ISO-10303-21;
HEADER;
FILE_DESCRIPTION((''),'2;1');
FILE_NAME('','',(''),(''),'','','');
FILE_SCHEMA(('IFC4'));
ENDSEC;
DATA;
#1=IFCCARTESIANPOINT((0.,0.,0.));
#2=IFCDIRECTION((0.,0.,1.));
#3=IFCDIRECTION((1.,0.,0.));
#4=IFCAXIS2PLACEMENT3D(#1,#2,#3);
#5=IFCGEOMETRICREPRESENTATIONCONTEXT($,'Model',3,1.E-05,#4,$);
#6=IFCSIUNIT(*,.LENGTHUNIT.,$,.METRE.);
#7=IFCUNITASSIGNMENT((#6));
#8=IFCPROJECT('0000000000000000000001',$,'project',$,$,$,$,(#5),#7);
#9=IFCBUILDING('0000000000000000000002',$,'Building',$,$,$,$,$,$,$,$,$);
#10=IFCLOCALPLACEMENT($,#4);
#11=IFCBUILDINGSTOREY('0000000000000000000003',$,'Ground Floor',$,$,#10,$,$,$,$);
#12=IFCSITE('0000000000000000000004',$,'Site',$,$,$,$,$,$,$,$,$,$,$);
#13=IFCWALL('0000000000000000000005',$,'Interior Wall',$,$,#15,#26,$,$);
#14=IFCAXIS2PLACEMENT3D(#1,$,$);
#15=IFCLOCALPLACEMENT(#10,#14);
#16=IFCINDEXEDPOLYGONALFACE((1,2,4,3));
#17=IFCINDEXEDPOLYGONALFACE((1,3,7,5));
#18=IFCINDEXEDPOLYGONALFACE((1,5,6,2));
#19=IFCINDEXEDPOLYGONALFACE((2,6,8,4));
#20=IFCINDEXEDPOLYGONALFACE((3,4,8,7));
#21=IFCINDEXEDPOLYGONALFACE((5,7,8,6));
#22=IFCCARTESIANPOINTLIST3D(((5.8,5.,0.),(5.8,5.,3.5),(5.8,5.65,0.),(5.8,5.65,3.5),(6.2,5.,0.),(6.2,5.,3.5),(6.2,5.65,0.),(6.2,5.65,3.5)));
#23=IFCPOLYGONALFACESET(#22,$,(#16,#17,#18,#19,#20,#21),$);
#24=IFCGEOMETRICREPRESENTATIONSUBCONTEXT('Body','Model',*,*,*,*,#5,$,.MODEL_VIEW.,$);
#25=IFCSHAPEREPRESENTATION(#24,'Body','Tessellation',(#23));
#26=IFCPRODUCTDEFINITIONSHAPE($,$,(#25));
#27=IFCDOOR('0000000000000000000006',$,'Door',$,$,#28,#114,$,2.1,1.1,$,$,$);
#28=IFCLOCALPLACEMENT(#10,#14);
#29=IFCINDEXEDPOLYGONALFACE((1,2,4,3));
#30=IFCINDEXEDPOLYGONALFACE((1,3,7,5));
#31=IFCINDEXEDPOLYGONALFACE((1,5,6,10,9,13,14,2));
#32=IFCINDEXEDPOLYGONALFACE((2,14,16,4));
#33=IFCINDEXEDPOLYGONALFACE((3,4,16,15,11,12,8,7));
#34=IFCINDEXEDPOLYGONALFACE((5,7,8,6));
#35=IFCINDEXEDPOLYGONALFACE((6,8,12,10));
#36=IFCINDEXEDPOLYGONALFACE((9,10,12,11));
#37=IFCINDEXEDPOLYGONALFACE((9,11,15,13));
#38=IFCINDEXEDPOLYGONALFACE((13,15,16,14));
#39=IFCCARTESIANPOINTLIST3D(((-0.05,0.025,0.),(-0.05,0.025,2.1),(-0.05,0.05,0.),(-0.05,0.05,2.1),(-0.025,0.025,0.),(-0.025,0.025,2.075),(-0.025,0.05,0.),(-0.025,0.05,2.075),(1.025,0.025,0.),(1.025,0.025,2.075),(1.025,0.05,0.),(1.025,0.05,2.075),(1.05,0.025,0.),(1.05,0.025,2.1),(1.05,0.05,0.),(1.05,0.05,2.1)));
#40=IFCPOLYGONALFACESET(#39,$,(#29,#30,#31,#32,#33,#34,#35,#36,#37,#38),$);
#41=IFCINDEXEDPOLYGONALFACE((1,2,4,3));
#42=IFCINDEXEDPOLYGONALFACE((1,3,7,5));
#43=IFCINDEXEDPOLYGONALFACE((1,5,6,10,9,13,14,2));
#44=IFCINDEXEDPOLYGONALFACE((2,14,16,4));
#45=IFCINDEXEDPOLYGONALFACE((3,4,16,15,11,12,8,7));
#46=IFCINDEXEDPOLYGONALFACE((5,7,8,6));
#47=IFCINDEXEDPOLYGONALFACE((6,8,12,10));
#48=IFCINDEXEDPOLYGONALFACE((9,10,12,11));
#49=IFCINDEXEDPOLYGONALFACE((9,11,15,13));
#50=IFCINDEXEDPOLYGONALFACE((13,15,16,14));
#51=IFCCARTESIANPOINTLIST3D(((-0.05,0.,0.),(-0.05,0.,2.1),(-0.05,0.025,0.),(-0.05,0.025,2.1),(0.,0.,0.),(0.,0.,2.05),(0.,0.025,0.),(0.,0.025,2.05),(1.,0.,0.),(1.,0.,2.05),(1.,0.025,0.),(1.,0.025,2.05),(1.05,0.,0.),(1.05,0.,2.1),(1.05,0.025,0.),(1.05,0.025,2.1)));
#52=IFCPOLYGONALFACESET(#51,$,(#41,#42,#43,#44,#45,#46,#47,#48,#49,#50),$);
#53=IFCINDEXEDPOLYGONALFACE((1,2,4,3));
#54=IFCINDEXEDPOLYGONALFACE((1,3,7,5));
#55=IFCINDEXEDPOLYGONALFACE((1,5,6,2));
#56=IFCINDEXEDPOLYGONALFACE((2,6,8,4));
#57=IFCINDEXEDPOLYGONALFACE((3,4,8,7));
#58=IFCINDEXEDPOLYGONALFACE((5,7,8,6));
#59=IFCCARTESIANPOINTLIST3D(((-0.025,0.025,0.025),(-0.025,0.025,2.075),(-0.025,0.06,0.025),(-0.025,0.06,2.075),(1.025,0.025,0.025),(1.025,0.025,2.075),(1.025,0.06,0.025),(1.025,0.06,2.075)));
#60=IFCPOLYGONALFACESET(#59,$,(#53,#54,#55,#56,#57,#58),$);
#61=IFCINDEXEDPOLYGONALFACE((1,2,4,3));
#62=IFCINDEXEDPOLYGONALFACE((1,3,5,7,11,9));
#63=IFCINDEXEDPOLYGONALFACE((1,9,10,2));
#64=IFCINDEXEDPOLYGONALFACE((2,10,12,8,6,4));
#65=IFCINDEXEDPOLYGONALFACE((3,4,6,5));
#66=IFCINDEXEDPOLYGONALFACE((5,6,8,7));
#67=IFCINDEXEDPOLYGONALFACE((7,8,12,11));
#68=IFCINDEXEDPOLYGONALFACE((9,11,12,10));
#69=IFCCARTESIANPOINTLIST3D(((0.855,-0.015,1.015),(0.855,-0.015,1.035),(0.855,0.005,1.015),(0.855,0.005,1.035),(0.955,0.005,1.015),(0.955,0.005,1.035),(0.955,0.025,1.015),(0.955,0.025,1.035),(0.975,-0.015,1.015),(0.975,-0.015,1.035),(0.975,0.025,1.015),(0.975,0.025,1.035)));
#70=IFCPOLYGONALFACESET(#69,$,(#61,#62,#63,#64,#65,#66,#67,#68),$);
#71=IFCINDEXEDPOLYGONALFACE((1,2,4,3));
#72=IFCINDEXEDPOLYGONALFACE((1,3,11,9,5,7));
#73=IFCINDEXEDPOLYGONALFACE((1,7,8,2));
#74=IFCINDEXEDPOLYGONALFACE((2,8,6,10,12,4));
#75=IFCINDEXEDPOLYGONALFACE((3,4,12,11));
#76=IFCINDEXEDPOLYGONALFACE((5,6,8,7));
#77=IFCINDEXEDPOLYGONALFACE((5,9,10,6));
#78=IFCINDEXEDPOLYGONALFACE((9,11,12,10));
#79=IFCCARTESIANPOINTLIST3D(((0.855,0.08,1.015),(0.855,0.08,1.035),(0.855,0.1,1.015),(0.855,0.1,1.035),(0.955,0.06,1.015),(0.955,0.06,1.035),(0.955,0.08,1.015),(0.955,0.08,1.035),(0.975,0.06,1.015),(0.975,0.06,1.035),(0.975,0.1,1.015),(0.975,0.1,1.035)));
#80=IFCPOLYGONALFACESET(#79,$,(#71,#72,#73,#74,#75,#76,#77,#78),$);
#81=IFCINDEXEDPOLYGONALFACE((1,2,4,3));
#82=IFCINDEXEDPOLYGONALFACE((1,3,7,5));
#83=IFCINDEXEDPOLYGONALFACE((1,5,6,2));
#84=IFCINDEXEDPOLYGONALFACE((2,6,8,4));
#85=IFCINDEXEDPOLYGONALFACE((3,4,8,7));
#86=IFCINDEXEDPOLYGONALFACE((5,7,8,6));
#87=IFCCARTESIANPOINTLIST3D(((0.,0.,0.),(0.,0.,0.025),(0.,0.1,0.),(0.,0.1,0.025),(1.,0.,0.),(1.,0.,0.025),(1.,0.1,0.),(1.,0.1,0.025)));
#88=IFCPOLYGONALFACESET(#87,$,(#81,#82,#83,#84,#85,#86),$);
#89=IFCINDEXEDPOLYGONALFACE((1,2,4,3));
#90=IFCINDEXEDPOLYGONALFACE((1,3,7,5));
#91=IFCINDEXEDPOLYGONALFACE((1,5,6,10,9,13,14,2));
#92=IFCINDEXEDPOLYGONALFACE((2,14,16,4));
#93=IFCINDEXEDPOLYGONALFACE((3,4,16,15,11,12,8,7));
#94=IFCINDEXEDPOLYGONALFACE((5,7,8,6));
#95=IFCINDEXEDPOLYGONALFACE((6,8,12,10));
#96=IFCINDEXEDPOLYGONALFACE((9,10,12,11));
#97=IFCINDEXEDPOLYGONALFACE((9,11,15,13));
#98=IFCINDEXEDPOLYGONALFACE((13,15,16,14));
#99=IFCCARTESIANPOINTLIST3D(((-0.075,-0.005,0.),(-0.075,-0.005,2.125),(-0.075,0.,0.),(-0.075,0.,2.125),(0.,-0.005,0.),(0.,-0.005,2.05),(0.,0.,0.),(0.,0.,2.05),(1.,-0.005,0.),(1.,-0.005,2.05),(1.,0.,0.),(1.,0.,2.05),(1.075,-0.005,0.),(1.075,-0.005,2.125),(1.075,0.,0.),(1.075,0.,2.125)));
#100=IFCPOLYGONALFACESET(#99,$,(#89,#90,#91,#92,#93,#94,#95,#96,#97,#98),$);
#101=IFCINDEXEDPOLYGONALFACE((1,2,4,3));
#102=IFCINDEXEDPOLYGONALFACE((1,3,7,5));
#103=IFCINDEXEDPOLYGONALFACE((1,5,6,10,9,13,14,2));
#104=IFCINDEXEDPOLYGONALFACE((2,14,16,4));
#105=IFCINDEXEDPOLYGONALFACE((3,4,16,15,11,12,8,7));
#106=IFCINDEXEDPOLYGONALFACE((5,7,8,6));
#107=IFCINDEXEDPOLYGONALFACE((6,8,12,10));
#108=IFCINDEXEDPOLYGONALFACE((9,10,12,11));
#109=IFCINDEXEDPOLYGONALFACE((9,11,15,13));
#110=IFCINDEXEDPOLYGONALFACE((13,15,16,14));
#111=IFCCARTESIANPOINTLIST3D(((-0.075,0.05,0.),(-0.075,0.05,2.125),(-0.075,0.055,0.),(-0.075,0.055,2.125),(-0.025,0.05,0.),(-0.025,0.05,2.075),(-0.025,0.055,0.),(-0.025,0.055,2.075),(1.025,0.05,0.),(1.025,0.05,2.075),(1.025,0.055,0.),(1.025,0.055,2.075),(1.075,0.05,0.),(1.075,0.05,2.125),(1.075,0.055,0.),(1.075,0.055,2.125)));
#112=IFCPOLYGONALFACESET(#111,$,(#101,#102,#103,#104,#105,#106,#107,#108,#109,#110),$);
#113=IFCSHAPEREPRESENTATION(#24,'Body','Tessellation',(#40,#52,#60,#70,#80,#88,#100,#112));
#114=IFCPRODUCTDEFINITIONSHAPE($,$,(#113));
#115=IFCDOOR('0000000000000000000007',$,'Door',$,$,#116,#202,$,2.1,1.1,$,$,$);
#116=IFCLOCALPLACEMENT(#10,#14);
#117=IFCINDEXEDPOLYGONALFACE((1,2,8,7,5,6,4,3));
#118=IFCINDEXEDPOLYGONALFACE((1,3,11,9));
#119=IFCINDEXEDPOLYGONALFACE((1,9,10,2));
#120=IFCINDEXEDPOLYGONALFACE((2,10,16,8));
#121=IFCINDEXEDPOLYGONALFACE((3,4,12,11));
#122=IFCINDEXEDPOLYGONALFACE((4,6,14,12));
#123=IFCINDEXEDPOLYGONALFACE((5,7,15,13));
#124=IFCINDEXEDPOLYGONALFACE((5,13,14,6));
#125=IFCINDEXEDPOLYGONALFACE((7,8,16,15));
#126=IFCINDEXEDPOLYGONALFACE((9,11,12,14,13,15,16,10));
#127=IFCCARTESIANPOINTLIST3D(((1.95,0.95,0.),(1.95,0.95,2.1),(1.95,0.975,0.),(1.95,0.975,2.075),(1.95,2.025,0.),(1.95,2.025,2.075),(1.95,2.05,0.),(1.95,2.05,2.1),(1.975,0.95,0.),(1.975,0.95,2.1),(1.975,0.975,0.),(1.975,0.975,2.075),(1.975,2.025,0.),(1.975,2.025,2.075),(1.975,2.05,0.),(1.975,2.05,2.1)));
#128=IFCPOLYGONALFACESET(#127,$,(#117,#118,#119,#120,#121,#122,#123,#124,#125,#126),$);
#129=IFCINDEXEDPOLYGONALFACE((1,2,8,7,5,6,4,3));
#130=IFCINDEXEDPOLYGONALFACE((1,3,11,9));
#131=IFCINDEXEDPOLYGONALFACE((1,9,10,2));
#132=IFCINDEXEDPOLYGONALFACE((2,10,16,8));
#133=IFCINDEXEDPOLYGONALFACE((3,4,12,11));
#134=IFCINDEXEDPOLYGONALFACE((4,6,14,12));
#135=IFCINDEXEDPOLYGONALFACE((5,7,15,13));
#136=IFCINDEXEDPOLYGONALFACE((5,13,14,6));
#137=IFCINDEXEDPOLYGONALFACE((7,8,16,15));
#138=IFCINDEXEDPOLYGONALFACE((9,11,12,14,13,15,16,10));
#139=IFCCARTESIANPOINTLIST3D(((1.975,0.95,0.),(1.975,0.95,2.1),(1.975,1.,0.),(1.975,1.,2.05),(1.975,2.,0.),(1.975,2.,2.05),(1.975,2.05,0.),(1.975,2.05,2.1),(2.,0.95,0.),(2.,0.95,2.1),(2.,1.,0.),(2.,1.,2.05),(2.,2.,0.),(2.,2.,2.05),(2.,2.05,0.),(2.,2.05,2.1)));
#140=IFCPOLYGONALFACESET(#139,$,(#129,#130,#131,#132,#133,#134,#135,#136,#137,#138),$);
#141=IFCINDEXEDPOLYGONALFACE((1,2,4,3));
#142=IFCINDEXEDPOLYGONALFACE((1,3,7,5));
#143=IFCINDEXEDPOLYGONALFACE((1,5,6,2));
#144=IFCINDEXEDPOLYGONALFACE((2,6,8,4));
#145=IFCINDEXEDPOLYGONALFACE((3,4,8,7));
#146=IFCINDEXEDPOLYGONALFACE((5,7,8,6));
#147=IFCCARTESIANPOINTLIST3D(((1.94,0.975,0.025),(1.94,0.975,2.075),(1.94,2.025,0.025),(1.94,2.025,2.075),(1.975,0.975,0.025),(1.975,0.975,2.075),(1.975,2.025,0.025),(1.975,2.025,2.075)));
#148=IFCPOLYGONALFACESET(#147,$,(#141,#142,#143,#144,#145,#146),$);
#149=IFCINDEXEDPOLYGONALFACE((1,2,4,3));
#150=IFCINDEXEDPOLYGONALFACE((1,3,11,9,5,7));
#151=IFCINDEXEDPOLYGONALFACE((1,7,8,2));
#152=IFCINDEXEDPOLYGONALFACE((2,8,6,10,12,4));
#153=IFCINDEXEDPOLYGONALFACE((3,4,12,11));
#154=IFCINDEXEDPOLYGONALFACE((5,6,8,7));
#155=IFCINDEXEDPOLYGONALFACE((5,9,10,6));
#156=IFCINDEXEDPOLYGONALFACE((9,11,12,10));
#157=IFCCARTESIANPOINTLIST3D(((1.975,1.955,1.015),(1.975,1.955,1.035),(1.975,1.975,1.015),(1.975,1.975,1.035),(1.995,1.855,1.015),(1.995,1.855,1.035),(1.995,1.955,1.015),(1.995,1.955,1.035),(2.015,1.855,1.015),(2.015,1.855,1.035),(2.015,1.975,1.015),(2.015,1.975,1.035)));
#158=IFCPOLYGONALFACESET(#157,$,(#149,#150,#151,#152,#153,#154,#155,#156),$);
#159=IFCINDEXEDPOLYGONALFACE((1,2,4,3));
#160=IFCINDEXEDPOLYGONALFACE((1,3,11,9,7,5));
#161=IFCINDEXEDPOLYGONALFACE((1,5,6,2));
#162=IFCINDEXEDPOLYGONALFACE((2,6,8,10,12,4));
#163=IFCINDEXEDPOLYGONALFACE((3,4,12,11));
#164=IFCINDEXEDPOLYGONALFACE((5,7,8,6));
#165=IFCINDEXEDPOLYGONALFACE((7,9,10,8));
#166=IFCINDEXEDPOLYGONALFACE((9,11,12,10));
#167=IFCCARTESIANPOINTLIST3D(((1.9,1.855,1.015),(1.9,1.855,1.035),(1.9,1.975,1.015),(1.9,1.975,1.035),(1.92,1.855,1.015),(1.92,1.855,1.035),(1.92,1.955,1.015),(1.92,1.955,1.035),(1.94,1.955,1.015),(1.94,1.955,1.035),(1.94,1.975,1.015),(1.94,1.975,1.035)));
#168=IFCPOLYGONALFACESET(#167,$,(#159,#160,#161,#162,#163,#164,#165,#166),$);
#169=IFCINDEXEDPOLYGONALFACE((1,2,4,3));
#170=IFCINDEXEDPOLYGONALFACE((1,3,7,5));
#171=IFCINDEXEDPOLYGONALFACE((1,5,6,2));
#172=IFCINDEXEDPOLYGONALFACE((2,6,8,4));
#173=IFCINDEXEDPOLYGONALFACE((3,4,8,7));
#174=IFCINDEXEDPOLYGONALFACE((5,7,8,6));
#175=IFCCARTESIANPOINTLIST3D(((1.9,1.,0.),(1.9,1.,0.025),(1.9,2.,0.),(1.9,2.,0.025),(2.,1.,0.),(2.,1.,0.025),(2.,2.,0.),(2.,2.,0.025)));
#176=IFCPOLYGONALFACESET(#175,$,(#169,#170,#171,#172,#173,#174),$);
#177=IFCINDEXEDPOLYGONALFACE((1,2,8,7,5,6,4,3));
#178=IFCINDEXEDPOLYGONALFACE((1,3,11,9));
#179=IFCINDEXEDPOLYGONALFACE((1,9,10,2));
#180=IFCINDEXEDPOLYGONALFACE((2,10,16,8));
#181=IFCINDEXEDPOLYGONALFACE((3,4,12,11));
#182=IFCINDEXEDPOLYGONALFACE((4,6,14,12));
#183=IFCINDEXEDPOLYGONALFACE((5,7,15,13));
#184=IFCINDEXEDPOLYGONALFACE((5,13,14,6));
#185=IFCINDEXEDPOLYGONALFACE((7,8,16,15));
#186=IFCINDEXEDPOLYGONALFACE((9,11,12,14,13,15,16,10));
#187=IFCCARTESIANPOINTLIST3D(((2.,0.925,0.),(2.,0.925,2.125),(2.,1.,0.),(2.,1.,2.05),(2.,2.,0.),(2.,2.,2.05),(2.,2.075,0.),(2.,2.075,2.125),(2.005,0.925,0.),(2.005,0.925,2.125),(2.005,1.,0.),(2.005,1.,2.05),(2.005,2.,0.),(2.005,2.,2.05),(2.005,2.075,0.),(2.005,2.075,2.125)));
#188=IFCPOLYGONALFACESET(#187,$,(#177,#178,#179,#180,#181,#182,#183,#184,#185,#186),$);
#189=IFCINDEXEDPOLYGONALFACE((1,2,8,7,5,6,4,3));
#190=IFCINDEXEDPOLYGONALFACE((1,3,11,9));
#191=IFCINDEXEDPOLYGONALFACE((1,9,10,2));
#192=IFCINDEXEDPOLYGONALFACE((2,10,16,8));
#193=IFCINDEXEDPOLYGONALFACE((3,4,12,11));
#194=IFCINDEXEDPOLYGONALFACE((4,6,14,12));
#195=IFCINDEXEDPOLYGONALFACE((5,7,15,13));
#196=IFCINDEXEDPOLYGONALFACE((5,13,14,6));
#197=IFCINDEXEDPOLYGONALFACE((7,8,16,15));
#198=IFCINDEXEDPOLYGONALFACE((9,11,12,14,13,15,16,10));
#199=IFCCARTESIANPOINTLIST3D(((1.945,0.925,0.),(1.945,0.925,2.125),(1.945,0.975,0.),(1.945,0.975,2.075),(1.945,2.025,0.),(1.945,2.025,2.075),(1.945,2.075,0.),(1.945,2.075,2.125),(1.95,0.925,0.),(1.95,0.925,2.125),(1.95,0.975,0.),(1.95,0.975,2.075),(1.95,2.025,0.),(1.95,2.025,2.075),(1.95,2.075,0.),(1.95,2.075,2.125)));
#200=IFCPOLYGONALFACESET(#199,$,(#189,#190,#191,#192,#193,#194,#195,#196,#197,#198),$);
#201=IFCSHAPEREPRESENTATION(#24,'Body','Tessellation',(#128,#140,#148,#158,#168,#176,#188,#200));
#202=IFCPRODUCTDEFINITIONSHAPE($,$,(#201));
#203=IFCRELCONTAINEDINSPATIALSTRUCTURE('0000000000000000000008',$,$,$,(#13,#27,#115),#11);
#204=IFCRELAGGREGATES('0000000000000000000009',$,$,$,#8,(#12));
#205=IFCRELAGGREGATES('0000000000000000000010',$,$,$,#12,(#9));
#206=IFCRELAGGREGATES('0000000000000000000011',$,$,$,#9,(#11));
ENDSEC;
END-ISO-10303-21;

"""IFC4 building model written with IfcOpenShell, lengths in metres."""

from ifc_helpers import new_model, si_unit, frame, origin_with_axes, place, context, subcontext, project, spatial, line, indexed_curve, outline, extrude, element, save


model = new_model("IFC4")

# Units and contexts
model_context = context("Model", 3, precision=1e-05, world=origin_with_axes())
body_context = subcontext(model_context, "Body", "Model", "MODEL_VIEW")
ifc_project = project(units=[si_unit("LENGTHUNIT", "METRE")], contexts=[model_context])

# Site, building, storey
site = spatial("IfcSite", under=ifc_project, Name="Site")
building = spatial("IfcBuilding", under=site, Name="Building")
storey_placement = place(None, origin_with_axes())
storey = spatial("IfcBuildingStorey", under=building, at=storey_placement, Name="Ground Floor")

# Wall
wall_1_placement = place(storey_placement, frame((6.0, 5.0, 0.0), z_axis=(0.0, 0.0, 1.0), x_axis=(0.0, 1.0, 0.0)))
element("IfcWall", 1, at=wall_1_placement, inside=storey, Name="Interior Wall", context=body_context, shape_type="SweptSolid", body=[
    extrude(outline(indexed_curve([(0.0, 0.0), (0.0, 0.4), (0.65, 0.4), (0.65, 0.0), (0.0, 0.0)], self_intersect=False)), frame((0.0, -0.2, 0.0), z_axis=(0.0, 0.0, 1.0), x_axis=(1.0, 0.0, 0.0)), (0.0, 0.0, 1.0), 3.5),
])

# Doors
door_1_placement = place(storey_placement, frame((-0.05, 0.0, 0.0), z_axis=(0.0, 0.0, 1.0), x_axis=(1.0, 0.0, 0.0)))
element("IfcDoor", 2, at=door_1_placement, inside=storey, Name="Door", OverallHeight=2.1, OverallWidth=1.1, context=body_context, shape_type="SweptSolid", body=[
    extrude(outline(indexed_curve([(0.0, 0.0), (0.0, 2.1), (1.1, 2.1), (1.1, 0.0), (1.075, 0.0), (1.075, 2.075), (0.025, 2.075), (0.025, 0.0)], segments=[line(1, 2, 3, 4, 5, 6, 7, 8, 1)])), frame((0.0, 0.025, 0.0), z_axis=(0.0, -1.0, 0.0), x_axis=(1.0, 0.0, 0.0)), (0.0, 0.0, -1.0), 0.025),
    extrude(outline(indexed_curve([(0.0, 0.0), (0.0, 2.1), (1.1, 2.1), (1.1, 0.0), (1.05, 0.0), (1.05, 2.05), (0.05, 2.05), (0.05, 0.0)], segments=[line(1, 2, 3, 4, 5, 6, 7, 8, 1)])), frame((0.0, 0.0, 0.0), z_axis=(0.0, -1.0, 0.0), x_axis=(1.0, 0.0, 0.0)), (0.0, 0.0, -1.0), 0.025),
    extrude(outline(indexed_curve([(0.0, 0.0), (1.05, 0.0), (1.05, 0.035), (0.0, 0.035)], segments=[line(1, 2, 3, 4, 1)])), frame((0.025, 0.025, 0.025), z_axis=(0.0, 0.0, 1.0), x_axis=(1.0, 0.0, 0.0)), (0.0, 0.0, 1.0), 2.05),
    extrude(outline(indexed_curve([(0.0, 0.0), (0.0, -0.04), (-0.12, -0.04), (-0.12, -0.02), (-0.02, -0.02), (-0.02, 0.0)], segments=[line(1, 2, 3, 4, 5, 6, 1)])), frame((1.025, 0.025, 1.015), z_axis=(0.0, 0.0, 1.0), x_axis=(1.0, 0.0, 0.0)), (0.0, 0.0, 1.0), 0.02),
    extrude(outline(indexed_curve([(0.0, 0.0), (0.0, 0.04), (-0.12, 0.04), (-0.12, 0.02), (-0.02, 0.02), (-0.02, 0.0)], segments=[line(1, 2, 3, 4, 5, 6, 1)])), frame((1.025, 0.06, 1.015), z_axis=(0.0, 0.0, 1.0), x_axis=(1.0, 0.0, 0.0)), (0.0, 0.0, 1.0), 0.02),
    extrude(outline(indexed_curve([(0.0, 0.0), (1.0, 0.0), (1.0, 0.1), (0.0, 0.1)], segments=[line(1, 2, 3, 4, 1)])), frame((0.05, 0.0, 0.0), z_axis=(0.0, 0.0, 1.0), x_axis=(1.0, 0.0, 0.0)), (0.0, 0.0, 1.0), 0.025),
    extrude(outline(indexed_curve([(0.0, 0.0), (0.0, 2.125), (1.15, 2.125), (1.15, 0.0), (1.075, 0.0), (1.075, 2.05), (0.075, 2.05), (0.075, 0.0)], segments=[line(1, 2, 3, 4, 5, 6, 7, 8, 1)])), frame((-0.025, -0.005, 0.0), z_axis=(0.0, -1.0, 0.0), x_axis=(1.0, 0.0, 0.0)), (0.0, 0.0, -1.0), 0.005),
    extrude(outline(indexed_curve([(0.0, 0.0), (0.0, 2.125), (1.15, 2.125), (1.15, 0.0), (1.1, 0.0), (1.1, 2.075), (0.05, 2.075), (0.05, 0.0)], segments=[line(1, 2, 3, 4, 5, 6, 7, 8, 1)])), frame((-0.025, 0.05, 0.0), z_axis=(0.0, -1.0, 0.0), x_axis=(1.0, 0.0, 0.0)), (0.0, 0.0, -1.0), 0.005),
])
door_2_placement = place(storey_placement, frame((2.0, 0.95, 0.0), z_axis=(0.0, 0.0, 1.0), x_axis=(0.0, 1.0, 0.0)))
element("IfcDoor", 3, at=door_2_placement, inside=storey, Name="Door", OverallHeight=2.1, OverallWidth=1.1, context=body_context, shape_type="SweptSolid", body=[
    extrude(outline(indexed_curve([(0.0, 0.0), (0.0, 2.1), (1.1, 2.1), (1.1, 0.0), (1.075, 0.0), (1.075, 2.075), (0.025, 2.075), (0.025, 0.0)], segments=[line(1, 2, 3, 4, 5, 6, 7, 8, 1)])), frame((0.0, 0.025, 0.0), z_axis=(0.0, -1.0, 0.0), x_axis=(1.0, 0.0, 0.0)), (0.0, 0.0, -1.0), 0.025),
    extrude(outline(indexed_curve([(0.0, 0.0), (0.0, 2.1), (1.1, 2.1), (1.1, 0.0), (1.05, 0.0), (1.05, 2.05), (0.05, 2.05), (0.05, 0.0)], segments=[line(1, 2, 3, 4, 5, 6, 7, 8, 1)])), frame((0.0, 0.0, 0.0), z_axis=(0.0, -1.0, 0.0), x_axis=(1.0, 0.0, 0.0)), (0.0, 0.0, -1.0), 0.025),
    extrude(outline(indexed_curve([(0.0, 0.0), (1.05, 0.0), (1.05, 0.035), (0.0, 0.035)], segments=[line(1, 2, 3, 4, 1)])), frame((0.025, 0.025, 0.025), z_axis=(0.0, 0.0, 1.0), x_axis=(1.0, 0.0, 0.0)), (0.0, 0.0, 1.0), 2.05),
    extrude(outline(indexed_curve([(0.0, 0.0), (0.0, -0.04), (-0.12, -0.04), (-0.12, -0.02), (-0.02, -0.02), (-0.02, 0.0)], segments=[line(1, 2, 3, 4, 5, 6, 1)])), frame((1.025, 0.025, 1.015), z_axis=(0.0, 0.0, 1.0), x_axis=(1.0, 0.0, 0.0)), (0.0, 0.0, 1.0), 0.02),
    extrude(outline(indexed_curve([(0.0, 0.0), (0.0, 0.04), (-0.12, 0.04), (-0.12, 0.02), (-0.02, 0.02), (-0.02, 0.0)], segments=[line(1, 2, 3, 4, 5, 6, 1)])), frame((1.025, 0.06, 1.015), z_axis=(0.0, 0.0, 1.0), x_axis=(1.0, 0.0, 0.0)), (0.0, 0.0, 1.0), 0.02),
    extrude(outline(indexed_curve([(0.0, 0.0), (1.0, 0.0), (1.0, 0.1), (0.0, 0.1)], segments=[line(1, 2, 3, 4, 1)])), frame((0.05, 0.0, 0.0), z_axis=(0.0, 0.0, 1.0), x_axis=(1.0, 0.0, 0.0)), (0.0, 0.0, 1.0), 0.025),
    extrude(outline(indexed_curve([(0.0, 0.0), (0.0, 2.125), (1.15, 2.125), (1.15, 0.0), (1.075, 0.0), (1.075, 2.05), (0.075, 2.05), (0.075, 0.0)], segments=[line(1, 2, 3, 4, 5, 6, 7, 8, 1)])), frame((-0.025, -0.005, 0.0), z_axis=(0.0, -1.0, 0.0), x_axis=(1.0, 0.0, 0.0)), (0.0, 0.0, -1.0), 0.005),
    extrude(outline(indexed_curve([(0.0, 0.0), (0.0, 2.125), (1.15, 2.125), (1.15, 0.0), (1.1, 0.0), (1.1, 2.075), (0.05, 2.075), (0.05, 0.0)], segments=[line(1, 2, 3, 4, 5, 6, 7, 8, 1)])), frame((-0.025, 0.05, 0.0), z_axis=(0.0, -1.0, 0.0), x_axis=(1.0, 0.0, 0.0)), (0.0, 0.0, -1.0), 0.005),
])

save(model, "model.ifc")
